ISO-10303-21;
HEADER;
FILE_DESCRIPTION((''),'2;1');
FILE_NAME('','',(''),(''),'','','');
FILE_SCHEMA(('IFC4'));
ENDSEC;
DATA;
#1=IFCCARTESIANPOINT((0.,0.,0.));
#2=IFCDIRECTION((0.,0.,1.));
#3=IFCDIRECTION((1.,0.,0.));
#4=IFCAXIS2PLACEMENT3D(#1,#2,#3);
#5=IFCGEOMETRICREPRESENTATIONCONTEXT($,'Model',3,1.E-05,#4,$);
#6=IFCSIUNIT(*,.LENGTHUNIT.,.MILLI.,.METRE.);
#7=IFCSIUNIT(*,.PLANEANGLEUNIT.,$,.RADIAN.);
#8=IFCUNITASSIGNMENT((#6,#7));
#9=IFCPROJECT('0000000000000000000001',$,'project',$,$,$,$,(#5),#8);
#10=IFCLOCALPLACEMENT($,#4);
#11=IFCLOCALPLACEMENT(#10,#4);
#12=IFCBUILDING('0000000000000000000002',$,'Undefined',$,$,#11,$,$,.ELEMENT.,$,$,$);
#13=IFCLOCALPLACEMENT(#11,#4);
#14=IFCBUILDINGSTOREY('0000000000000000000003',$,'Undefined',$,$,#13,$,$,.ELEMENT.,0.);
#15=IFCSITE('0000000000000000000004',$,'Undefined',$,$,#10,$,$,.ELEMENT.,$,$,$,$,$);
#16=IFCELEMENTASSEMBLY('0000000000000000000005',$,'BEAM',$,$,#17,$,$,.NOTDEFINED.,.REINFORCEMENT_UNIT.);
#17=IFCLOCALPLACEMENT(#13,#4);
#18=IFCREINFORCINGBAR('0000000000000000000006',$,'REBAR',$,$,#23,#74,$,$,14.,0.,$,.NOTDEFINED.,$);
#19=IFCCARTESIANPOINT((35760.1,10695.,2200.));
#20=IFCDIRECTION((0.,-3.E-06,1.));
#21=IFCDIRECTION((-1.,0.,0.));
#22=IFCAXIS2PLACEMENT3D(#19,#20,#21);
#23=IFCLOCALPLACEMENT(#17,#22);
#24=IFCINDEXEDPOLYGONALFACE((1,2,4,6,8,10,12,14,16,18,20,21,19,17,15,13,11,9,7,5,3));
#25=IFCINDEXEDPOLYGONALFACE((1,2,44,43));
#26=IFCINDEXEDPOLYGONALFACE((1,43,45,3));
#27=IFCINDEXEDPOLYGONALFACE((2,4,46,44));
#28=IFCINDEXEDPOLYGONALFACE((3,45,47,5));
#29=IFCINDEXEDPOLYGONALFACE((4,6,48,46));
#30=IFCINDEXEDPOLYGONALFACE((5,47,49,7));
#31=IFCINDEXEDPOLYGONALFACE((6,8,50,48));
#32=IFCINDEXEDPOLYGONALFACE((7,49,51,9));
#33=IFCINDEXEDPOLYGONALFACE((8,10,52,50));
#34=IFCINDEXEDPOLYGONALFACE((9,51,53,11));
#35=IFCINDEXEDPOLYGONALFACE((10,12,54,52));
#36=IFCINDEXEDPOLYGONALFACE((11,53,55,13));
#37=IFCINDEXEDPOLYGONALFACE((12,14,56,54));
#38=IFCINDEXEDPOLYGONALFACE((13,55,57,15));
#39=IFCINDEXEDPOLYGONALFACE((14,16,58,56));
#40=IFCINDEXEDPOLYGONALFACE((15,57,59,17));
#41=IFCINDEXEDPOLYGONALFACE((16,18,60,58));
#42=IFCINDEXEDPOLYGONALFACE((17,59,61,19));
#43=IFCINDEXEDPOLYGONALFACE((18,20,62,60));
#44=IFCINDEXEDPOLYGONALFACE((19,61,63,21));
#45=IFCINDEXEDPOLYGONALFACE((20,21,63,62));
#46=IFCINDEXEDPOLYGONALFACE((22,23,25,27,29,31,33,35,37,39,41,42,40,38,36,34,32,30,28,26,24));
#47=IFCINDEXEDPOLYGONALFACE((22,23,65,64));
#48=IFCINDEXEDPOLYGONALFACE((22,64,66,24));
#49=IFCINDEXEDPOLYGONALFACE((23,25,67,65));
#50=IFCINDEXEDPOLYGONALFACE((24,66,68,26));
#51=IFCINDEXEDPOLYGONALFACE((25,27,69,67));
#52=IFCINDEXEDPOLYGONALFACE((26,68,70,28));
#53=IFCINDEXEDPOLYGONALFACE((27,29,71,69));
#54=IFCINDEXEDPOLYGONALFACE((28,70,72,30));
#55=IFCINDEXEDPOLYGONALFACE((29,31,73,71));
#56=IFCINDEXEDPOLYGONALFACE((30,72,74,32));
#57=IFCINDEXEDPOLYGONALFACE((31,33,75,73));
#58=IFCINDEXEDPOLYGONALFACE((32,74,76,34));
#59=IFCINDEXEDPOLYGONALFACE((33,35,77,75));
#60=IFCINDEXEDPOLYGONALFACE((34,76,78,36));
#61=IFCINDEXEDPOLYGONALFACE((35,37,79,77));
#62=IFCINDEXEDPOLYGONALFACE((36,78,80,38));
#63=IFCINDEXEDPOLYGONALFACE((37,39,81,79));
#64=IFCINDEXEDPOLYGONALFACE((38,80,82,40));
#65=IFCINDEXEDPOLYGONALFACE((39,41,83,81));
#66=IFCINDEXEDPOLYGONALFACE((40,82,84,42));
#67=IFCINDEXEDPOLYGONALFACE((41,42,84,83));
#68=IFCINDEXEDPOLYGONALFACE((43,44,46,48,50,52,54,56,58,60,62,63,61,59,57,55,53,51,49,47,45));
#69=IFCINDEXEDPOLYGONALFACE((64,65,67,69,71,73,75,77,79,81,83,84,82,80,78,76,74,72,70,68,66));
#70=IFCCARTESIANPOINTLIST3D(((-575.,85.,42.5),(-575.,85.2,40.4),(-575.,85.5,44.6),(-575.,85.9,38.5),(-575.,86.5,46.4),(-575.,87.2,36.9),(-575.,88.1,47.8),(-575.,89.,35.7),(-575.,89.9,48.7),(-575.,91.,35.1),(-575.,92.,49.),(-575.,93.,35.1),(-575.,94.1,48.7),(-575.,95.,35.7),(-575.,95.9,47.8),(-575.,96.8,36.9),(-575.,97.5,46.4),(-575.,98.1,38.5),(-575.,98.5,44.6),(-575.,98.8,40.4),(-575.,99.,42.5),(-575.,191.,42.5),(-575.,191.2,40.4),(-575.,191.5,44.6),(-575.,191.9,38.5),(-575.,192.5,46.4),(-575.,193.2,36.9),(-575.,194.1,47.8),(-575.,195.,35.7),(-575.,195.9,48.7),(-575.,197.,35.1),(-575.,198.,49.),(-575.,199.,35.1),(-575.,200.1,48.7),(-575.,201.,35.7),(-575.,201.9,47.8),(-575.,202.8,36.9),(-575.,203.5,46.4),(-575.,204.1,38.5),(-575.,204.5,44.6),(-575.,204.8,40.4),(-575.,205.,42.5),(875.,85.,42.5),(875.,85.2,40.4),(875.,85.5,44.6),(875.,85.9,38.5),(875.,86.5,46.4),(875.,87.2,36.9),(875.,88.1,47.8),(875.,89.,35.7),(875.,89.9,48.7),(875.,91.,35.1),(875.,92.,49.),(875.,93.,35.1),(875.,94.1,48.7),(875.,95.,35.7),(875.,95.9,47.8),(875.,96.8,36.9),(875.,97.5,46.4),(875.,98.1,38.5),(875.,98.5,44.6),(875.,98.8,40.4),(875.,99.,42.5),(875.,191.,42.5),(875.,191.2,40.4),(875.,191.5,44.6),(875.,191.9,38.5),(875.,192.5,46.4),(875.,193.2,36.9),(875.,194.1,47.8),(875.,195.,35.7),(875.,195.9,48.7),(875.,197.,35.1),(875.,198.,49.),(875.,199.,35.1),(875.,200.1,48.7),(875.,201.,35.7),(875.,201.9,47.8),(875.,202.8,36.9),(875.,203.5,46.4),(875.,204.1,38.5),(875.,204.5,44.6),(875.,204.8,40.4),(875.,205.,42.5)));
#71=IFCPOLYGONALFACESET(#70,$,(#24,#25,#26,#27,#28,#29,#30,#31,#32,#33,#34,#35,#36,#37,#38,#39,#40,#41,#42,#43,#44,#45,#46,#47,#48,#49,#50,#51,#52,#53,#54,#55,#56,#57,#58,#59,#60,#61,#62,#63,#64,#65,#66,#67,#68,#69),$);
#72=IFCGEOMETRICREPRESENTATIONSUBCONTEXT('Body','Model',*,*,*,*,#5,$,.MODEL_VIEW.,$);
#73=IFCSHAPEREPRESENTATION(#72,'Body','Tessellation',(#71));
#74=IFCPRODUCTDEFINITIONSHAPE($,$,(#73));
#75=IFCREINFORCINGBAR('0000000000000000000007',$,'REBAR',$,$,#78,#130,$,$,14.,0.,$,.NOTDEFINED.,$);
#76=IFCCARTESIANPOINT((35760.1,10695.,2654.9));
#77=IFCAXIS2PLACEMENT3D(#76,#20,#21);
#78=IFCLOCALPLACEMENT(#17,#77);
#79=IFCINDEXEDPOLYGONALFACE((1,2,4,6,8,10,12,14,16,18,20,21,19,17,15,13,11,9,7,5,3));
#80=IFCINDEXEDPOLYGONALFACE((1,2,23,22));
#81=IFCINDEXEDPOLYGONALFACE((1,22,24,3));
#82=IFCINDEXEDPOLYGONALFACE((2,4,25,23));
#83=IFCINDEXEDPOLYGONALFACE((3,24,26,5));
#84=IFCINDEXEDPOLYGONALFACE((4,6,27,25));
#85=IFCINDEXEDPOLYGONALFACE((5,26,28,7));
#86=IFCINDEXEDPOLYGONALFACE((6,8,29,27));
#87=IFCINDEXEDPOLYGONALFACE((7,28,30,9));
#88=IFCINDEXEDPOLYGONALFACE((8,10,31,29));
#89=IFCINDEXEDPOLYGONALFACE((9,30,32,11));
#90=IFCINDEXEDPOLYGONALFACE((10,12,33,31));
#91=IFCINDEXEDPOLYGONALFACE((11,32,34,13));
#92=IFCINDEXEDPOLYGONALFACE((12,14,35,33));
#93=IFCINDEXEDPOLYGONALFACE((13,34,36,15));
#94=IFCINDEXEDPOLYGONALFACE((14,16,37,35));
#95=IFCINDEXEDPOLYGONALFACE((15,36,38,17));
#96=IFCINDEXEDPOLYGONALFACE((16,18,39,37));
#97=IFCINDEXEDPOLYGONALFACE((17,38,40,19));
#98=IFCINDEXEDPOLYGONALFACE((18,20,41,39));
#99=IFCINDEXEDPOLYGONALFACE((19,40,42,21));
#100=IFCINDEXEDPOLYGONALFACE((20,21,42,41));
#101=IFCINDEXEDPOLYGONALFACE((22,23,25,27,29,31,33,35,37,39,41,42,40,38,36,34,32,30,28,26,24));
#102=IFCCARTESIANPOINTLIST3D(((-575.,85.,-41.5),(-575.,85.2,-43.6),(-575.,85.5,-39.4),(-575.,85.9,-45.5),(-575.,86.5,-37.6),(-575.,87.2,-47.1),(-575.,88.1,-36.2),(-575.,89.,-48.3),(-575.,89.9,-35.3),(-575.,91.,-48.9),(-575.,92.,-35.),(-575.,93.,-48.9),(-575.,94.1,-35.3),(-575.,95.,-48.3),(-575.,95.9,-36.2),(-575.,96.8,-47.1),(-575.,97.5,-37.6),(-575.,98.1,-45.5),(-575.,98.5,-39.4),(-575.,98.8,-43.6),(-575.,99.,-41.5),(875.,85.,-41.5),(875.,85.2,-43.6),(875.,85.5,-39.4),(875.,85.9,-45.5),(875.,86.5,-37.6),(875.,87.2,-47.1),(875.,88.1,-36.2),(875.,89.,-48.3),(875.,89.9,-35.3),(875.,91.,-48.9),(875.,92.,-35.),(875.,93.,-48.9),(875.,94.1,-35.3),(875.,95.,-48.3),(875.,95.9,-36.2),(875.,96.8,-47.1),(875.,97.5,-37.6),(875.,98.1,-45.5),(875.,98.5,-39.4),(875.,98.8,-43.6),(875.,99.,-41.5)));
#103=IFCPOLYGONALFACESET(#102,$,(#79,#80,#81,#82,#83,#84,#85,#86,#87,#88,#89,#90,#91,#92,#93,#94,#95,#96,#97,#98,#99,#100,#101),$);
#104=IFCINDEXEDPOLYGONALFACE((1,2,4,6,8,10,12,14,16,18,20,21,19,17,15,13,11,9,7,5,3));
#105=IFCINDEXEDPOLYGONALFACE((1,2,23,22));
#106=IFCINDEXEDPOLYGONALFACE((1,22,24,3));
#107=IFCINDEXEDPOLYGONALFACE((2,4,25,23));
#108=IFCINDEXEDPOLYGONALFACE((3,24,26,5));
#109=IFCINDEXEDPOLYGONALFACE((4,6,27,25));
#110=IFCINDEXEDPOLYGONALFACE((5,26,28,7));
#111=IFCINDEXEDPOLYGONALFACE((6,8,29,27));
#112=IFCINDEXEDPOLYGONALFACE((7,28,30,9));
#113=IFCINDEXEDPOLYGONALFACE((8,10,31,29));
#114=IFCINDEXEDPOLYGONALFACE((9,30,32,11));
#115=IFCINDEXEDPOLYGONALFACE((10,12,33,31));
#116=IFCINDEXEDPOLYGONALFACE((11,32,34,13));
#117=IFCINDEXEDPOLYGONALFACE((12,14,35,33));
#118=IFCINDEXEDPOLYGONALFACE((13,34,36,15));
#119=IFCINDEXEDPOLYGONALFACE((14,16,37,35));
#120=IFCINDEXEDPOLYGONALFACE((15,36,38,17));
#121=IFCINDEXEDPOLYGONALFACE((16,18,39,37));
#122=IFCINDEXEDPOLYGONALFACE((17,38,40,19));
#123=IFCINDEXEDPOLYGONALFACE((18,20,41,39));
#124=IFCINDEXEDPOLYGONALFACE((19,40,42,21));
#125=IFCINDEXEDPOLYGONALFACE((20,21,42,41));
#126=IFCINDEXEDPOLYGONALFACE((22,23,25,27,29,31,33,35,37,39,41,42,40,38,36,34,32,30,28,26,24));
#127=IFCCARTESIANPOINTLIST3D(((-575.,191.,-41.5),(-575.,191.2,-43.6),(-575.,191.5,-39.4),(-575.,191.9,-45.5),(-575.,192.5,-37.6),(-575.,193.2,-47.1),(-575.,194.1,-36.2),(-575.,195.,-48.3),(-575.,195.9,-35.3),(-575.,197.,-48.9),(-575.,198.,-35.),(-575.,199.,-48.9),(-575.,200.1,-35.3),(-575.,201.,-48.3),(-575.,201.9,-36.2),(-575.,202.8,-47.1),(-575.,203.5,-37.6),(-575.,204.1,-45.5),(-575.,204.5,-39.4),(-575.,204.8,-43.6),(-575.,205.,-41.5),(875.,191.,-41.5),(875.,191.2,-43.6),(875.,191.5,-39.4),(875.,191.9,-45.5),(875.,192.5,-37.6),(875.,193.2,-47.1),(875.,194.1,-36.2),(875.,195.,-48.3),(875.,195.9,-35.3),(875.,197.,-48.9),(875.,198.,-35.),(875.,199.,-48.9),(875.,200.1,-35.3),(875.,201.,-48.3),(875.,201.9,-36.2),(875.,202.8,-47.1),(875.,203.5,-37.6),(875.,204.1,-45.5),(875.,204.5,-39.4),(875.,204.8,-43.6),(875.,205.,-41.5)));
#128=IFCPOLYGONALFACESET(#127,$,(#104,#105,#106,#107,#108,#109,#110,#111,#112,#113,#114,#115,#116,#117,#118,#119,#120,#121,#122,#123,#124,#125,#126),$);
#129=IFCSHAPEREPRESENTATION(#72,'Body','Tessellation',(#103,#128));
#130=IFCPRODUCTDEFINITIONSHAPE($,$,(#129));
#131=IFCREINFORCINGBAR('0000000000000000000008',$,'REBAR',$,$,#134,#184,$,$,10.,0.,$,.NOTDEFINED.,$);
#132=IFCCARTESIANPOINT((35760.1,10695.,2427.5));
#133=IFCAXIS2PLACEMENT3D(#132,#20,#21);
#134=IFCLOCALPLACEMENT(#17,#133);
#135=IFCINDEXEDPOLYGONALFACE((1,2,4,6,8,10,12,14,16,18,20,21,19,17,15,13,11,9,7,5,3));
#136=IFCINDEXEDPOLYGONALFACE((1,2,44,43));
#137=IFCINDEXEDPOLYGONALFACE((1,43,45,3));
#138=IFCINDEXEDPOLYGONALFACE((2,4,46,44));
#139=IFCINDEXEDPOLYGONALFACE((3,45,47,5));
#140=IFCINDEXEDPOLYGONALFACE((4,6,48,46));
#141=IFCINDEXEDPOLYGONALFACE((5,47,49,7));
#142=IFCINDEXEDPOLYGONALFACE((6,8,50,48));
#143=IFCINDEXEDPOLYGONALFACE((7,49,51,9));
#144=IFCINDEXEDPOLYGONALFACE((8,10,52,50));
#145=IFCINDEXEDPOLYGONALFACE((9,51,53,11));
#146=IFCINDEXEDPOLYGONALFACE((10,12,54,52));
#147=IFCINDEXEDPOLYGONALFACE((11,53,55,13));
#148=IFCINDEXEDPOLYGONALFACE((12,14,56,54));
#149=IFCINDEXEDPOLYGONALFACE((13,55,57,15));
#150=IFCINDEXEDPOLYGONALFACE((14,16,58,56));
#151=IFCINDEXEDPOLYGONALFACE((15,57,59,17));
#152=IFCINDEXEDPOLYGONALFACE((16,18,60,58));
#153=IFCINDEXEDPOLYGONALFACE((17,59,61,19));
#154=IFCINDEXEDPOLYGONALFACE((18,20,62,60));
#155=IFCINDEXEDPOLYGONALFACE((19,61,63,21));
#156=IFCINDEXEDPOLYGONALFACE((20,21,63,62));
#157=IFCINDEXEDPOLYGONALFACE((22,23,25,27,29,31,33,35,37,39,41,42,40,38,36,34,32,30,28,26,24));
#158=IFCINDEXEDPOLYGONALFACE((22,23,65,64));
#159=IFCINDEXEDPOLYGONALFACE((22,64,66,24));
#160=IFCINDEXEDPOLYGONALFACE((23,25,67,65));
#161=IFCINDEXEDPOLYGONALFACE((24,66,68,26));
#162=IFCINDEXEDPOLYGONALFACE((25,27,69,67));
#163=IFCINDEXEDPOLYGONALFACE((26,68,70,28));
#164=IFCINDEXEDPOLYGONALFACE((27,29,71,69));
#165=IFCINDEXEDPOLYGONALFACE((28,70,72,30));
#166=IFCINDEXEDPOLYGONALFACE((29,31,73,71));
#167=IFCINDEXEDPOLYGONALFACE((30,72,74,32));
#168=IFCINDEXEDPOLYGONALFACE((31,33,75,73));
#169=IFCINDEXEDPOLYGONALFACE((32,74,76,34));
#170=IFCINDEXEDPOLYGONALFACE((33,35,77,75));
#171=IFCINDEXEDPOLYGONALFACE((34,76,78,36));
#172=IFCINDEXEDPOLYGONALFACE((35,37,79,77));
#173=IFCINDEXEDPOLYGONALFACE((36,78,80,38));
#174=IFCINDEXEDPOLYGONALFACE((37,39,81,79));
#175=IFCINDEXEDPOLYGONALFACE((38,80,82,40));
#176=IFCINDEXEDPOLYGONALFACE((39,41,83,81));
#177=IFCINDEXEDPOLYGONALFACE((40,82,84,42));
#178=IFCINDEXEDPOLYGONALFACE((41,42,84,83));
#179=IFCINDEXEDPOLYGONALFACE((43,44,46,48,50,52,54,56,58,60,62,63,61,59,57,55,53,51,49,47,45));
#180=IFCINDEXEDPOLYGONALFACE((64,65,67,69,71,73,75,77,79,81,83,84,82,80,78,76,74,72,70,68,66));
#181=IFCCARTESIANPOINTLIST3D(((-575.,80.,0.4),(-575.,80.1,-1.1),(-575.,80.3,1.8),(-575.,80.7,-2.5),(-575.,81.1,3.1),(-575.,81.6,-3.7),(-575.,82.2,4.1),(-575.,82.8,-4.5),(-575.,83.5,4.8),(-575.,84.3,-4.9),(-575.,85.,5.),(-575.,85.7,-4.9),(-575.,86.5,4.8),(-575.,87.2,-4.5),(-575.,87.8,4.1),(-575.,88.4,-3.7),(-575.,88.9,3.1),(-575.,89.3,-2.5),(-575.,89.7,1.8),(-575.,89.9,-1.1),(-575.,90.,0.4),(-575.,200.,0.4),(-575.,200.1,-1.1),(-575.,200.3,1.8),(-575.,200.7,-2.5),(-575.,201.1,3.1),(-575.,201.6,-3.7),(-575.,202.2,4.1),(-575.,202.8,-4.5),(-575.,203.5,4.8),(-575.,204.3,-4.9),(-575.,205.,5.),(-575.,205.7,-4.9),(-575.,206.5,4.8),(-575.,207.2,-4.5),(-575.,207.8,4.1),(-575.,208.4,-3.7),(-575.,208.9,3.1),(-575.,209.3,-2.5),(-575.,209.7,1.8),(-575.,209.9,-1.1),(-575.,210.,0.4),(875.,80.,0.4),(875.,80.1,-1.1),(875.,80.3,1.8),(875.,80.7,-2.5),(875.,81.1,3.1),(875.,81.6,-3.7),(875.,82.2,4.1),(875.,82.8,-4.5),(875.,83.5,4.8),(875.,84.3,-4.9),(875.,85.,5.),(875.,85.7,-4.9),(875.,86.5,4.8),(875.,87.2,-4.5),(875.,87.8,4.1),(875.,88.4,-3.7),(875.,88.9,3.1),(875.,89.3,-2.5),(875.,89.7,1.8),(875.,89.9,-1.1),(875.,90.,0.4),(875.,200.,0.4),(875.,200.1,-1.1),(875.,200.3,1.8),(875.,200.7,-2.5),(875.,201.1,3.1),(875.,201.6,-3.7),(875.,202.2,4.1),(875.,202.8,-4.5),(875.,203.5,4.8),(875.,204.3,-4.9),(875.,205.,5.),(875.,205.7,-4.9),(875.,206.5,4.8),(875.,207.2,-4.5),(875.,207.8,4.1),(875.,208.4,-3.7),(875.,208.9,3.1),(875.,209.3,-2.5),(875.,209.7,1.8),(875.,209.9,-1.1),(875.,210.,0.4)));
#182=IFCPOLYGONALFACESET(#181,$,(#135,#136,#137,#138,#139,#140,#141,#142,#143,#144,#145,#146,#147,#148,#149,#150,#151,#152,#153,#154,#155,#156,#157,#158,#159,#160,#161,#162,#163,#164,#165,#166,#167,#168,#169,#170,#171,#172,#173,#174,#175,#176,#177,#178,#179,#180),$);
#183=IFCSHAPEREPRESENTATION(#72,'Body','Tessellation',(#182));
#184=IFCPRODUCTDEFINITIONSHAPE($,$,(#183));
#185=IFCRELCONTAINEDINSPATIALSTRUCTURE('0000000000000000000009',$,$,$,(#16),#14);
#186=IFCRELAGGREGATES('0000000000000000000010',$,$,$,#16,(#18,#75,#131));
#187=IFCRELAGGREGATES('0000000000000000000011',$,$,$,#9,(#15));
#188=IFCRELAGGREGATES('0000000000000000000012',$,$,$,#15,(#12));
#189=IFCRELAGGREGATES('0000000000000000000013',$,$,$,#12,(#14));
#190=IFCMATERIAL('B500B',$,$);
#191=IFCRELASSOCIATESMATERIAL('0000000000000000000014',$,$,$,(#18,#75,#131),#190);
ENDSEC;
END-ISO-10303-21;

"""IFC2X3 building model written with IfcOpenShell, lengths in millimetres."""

from ifc_helpers import new_model, entity, si_unit, frame, origin_with_axes, place, context, subcontext, project, spatial, source, transform, mapped, material, element, aggregate, save


model = new_model("IFC2X3")

# Units and contexts
model_context = context("Model", 3, precision=1e-05, world=origin_with_axes())
body_context = subcontext(model_context, "Body", "Model", "MODEL_VIEW")
ifc_project = project(units=[si_unit("LENGTHUNIT", "METRE", prefix="MILLI"), si_unit("PLANEANGLEUNIT", "RADIAN")], contexts=[model_context])

# Site, building, storey
site_placement = place(None, origin_with_axes())
site = spatial("IfcSite", under=ifc_project, at=site_placement, Name="Undefined", CompositionType="ELEMENT")
building_placement = place(site_placement, origin_with_axes())
building = spatial("IfcBuilding", under=site, at=building_placement, Name="Undefined", CompositionType="ELEMENT")
storey_placement = place(building_placement, origin_with_axes())
storey = spatial("IfcBuildingStorey", under=building, at=storey_placement, Name="Undefined", CompositionType="ELEMENT", Elevation=0.0)

# Shared definitions
ifc_material_1 = material(Name="B500B")

# Element assembly, reinforcing bars
assembly_1_placement = place(storey_placement, origin_with_axes())
assembly_1 = element("IfcElementAssembly", 1, at=assembly_1_placement, inside=storey, Name="BEAM", AssemblyPlace="NOTDEFINED", PredefinedType="REINFORCEMENT_UNIT")
shared_shape_1 = source(origin_with_axes(), body_context, "Body", "AdvancedSweptSolid", [
    entity("IfcSweptDiskSolid", entity("IfcTrimmedCurve", entity("IfcLine", entity("IfcCartesianPoint", [0.0, 0.0, 0.0]), entity("IfcVector", entity("IfcDirection", [1.0, 0.0, 0.0]), 1.0)), [entity("IfcParameterValue", 0.0)], [entity("IfcParameterValue", 1449.999613)], True, "PARAMETER"), 7.0, None, 0.0, 1450.0),
])
shared_shape_2 = source(origin_with_axes(), body_context, "Body", "AdvancedSweptSolid", [
    entity("IfcSweptDiskSolid", entity("IfcTrimmedCurve", entity("IfcLine", entity("IfcCartesianPoint", [0.0, 0.0, 0.0]), entity("IfcVector", entity("IfcDirection", [1.0, 0.0, 0.0]), 1.0)), [entity("IfcParameterValue", 0.0)], [entity("IfcParameterValue", 1449.999613)], True, "PARAMETER"), 7.0, None, 0.0, 1450.0),
])
reinforcing_bar_1_placement = place(assembly_1_placement, frame((35760.1, 10695.0, 2200.0), z_axis=(0.0, -0.000003, 1.0), x_axis=(-1.0, 0.0, 0.0)))
reinforcing_bar_1 = element("IfcReinforcingBar", 2, at=reinforcing_bar_1_placement, material=ifc_material_1, Name="REBAR", BarRole="NOTDEFINED", CrossSectionArea=0.0, NominalDiameter=14.0, context=body_context, shape_type="MappedRepresentation", body=[
    mapped(shared_shape_1, transform((-575.0, 92.0, 42.0))),
    mapped(shared_shape_2, transform((-575.0, 198.0, 42.0))),
])
shared_shape_3 = source(origin_with_axes(), body_context, "Body", "AdvancedSweptSolid", [
    entity("IfcSweptDiskSolid", entity("IfcTrimmedCurve", entity("IfcLine", entity("IfcCartesianPoint", [0.0, 0.0, 0.0]), entity("IfcVector", entity("IfcDirection", [1.0, 0.0, 0.0]), 1.0)), [entity("IfcParameterValue", 0.0)], [entity("IfcParameterValue", 1449.999613)], True, "PARAMETER"), 7.0, None, 0.0, 1450.0),
])
shared_shape_4 = source(origin_with_axes(), body_context, "Body", "AdvancedSweptSolid", [
    entity("IfcSweptDiskSolid", entity("IfcTrimmedCurve", entity("IfcLine", entity("IfcCartesianPoint", [0.0, 0.0, 0.0]), entity("IfcVector", entity("IfcDirection", [1.0, 0.0, 0.0]), 1.0)), [entity("IfcParameterValue", 0.0)], [entity("IfcParameterValue", 1449.999613)], True, "PARAMETER"), 7.0, None, 0.0, 1450.0),
])
reinforcing_bar_2_placement = place(assembly_1_placement, frame((35760.1, 10695.0, 2654.9), z_axis=(0.0, -0.000003, 1.0), x_axis=(-1.0, 0.0, 0.0)))
reinforcing_bar_2 = element("IfcReinforcingBar", 3, at=reinforcing_bar_2_placement, material=ifc_material_1, Name="REBAR", BarRole="NOTDEFINED", CrossSectionArea=0.0, NominalDiameter=14.0, context=body_context, shape_type="MappedRepresentation", body=[
    mapped(shared_shape_3, transform((-575.0, 92.0, -42.0))),
    mapped(shared_shape_4, transform((-575.0, 198.0, -42.0))),
])
shared_shape_5 = source(origin_with_axes(), body_context, "Body", "AdvancedSweptSolid", [
    entity("IfcSweptDiskSolid", entity("IfcTrimmedCurve", entity("IfcLine", entity("IfcCartesianPoint", [0.0, 0.0, 0.0]), entity("IfcVector", entity("IfcDirection", [1.0, 0.0, 0.0]), 1.0)), [entity("IfcParameterValue", 0.0)], [entity("IfcParameterValue", 1449.999613)], True, "PARAMETER"), 5.0, None, 0.0, 1450.0),
])
shared_shape_6 = source(origin_with_axes(), body_context, "Body", "AdvancedSweptSolid", [
    entity("IfcSweptDiskSolid", entity("IfcTrimmedCurve", entity("IfcLine", entity("IfcCartesianPoint", [0.0, 0.0, 0.0]), entity("IfcVector", entity("IfcDirection", [1.0, 0.0, 0.0]), 1.0)), [entity("IfcParameterValue", 0.0)], [entity("IfcParameterValue", 1449.999613)], True, "PARAMETER"), 5.0, None, 0.0, 1450.0),
])
reinforcing_bar_3_placement = place(assembly_1_placement, frame((35760.1, 10695.0, 2427.5), z_axis=(0.0, -0.000003, 1.0), x_axis=(-1.0, 0.0, 0.0)))
reinforcing_bar_3 = element("IfcReinforcingBar", 4, at=reinforcing_bar_3_placement, material=ifc_material_1, Name="REBAR", BarRole="NOTDEFINED", CrossSectionArea=0.0, NominalDiameter=10.0, context=body_context, shape_type="MappedRepresentation", body=[
    mapped(shared_shape_5, transform((-575.0, 85.0, 0.0))),
    mapped(shared_shape_6, transform((-575.0, 205.0, 0.0))),
])
aggregate(assembly_1, [reinforcing_bar_1, reinforcing_bar_2, reinforcing_bar_3])

save(model, "model.ifc")
